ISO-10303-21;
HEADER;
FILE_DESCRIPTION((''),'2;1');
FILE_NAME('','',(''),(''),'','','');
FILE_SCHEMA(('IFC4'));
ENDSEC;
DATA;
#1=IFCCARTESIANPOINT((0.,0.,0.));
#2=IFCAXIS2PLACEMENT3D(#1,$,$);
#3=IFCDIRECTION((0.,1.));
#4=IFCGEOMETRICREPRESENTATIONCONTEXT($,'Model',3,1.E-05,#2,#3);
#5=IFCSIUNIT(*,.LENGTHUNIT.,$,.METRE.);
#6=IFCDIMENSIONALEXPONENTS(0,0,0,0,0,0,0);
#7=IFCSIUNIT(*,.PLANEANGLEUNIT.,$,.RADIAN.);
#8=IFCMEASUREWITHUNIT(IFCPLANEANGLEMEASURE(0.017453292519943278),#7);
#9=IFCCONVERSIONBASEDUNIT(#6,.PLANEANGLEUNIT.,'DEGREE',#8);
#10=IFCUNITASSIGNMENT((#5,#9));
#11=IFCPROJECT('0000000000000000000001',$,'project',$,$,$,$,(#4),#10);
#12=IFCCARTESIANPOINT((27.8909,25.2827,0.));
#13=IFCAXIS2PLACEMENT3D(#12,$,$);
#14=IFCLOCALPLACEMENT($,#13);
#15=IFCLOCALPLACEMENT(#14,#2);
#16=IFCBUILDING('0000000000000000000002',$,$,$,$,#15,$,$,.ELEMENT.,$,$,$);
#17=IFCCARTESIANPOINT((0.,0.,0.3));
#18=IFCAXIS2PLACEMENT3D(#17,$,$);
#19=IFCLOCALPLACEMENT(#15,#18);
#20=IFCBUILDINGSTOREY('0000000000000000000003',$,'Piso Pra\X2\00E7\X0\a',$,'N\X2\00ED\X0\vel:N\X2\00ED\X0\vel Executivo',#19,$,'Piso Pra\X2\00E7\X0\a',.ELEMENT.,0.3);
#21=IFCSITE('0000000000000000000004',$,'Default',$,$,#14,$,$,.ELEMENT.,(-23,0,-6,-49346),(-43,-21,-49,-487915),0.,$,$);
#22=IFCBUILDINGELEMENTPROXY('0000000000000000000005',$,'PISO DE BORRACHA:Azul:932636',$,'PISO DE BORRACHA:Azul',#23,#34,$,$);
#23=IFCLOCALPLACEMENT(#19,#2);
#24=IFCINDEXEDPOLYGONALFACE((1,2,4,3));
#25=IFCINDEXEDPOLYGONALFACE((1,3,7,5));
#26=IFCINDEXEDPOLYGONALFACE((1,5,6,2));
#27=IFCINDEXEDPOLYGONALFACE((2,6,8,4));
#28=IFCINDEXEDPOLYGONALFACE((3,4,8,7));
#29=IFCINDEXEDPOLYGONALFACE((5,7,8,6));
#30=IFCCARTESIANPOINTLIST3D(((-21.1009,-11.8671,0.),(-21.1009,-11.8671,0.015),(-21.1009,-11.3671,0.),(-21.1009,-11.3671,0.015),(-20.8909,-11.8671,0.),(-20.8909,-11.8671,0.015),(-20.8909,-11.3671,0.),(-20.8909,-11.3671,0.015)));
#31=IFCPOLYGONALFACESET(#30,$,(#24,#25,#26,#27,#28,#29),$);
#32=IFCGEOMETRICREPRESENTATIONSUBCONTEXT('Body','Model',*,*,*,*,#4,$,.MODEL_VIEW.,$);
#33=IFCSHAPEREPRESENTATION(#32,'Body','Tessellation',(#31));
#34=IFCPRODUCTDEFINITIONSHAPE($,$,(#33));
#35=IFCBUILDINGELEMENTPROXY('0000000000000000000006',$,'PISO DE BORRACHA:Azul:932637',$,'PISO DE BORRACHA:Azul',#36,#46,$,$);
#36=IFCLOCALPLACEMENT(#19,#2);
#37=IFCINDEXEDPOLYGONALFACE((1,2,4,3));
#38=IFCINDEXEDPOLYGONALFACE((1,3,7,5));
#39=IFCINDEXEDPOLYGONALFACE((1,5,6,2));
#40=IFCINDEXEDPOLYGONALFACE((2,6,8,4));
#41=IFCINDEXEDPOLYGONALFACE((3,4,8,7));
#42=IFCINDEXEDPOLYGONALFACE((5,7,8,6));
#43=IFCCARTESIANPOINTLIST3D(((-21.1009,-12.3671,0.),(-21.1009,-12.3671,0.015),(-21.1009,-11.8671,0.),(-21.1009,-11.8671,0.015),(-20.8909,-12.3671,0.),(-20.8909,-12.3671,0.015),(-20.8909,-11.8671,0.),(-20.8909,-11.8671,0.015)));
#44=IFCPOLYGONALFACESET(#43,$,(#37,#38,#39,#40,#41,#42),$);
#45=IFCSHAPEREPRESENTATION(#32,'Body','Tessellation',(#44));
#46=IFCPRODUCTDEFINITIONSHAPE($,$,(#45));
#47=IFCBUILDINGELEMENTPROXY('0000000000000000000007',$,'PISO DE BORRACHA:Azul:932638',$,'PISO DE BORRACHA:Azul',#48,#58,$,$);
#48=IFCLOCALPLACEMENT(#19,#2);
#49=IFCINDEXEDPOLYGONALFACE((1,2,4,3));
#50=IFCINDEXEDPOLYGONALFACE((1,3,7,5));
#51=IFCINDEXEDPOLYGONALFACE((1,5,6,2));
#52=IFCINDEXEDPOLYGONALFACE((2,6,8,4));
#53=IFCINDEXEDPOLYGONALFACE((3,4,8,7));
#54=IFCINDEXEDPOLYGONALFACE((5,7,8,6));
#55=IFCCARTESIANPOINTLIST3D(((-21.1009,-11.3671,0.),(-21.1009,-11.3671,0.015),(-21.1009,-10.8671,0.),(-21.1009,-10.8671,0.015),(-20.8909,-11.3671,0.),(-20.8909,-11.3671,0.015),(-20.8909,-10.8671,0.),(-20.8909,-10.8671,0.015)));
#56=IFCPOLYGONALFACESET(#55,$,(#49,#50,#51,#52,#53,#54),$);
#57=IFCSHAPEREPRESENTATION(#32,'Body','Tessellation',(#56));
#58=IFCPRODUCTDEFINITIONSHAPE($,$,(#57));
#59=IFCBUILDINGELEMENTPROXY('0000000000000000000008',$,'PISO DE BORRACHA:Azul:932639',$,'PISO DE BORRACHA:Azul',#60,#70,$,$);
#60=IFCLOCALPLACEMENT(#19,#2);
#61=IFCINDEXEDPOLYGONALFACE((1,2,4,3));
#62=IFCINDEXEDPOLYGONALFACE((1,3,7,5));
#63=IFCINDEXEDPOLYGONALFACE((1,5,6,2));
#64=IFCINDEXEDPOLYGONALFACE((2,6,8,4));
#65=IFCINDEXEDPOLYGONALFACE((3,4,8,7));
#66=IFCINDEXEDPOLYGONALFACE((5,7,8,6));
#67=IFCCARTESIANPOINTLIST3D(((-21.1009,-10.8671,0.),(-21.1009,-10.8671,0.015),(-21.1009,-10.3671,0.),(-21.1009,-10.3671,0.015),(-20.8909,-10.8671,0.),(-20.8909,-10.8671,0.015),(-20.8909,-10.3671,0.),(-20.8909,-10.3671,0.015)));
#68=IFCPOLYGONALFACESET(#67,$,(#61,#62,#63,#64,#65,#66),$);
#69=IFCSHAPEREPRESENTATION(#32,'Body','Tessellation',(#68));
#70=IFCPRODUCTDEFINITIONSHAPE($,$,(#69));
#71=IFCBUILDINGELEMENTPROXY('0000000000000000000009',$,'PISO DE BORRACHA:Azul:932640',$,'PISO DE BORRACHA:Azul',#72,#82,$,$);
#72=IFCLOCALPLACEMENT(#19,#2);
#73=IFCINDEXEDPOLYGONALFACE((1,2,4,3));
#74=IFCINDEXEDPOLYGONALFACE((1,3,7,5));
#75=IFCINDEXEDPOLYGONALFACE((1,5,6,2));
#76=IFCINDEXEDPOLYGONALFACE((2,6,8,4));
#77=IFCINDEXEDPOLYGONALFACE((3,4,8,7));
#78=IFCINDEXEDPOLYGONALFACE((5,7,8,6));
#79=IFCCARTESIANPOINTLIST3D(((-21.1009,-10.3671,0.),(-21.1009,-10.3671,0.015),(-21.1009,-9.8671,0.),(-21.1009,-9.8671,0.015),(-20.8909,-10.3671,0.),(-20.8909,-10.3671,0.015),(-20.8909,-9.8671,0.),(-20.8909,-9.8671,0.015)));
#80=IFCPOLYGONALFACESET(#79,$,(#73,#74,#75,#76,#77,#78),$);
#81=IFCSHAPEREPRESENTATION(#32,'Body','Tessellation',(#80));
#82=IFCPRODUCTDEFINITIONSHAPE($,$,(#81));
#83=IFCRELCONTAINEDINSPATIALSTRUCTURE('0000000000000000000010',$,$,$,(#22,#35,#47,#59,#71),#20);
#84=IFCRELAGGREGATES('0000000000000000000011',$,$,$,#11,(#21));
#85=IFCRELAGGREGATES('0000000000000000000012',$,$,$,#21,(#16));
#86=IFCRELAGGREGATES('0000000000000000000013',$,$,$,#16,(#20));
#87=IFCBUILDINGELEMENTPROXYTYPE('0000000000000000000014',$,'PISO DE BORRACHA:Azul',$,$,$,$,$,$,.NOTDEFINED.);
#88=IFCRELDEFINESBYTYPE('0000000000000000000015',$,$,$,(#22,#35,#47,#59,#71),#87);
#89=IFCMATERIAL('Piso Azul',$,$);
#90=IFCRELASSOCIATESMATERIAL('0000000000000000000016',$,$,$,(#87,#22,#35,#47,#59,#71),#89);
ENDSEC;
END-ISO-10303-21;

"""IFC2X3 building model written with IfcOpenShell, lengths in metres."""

from ifc_helpers import new_model, entity, si_unit, converted_unit, direction, frame, origin, origin_2d_with_axis, place, context, subcontext, project, spatial, rectangle, extrude, source, transform, mapped, material, type_object, type_shapes, element, save


model = new_model("IFC2X3")

# Units and contexts
model_context = context("Model", 3, precision=1e-05, world=origin(), true_north=direction((0.0, 1.0)))
body_context = subcontext(model_context, "Body", "Model", "MODEL_VIEW")
ifc_project = project(units=[si_unit("LENGTHUNIT", "METRE"), converted_unit("PLANEANGLEUNIT", "DEGREE", entity("IfcPlaneAngleMeasure", 0.017453292519943278), si_unit("PLANEANGLEUNIT", "RADIAN"), dimensions=[0, 0, 0, 0, 0, 0, 0])], contexts=[model_context])

# Site, building, storey
site_placement = place(None, frame((27.8909, 25.2827, 0.0)))
site = spatial("IfcSite", under=ifc_project, at=site_placement, Name="Default", CompositionType="ELEMENT", RefLatitude=(-23, 0, -6, -49346), RefLongitude=(-43, -21, -49, -487915), RefElevation=0.0)
building_placement = place(site_placement, origin())
building = spatial("IfcBuilding", under=site, at=building_placement, CompositionType="ELEMENT")
storey_placement = place(building_placement, frame((0.0, 0.0, 0.3)))
storey = spatial("IfcBuildingStorey", under=building, at=storey_placement, Name="Piso Praça", ObjectType="Nível:Nível Executivo", LongName="Piso Praça", CompositionType="ELEMENT", Elevation=0.3)

# Building element proxies
ifc_material_1 = material(Name="Piso Azul")
building_element_proxy_type_1 = type_object("IfcBuildingElementProxyType", Name="PISO DE BORRACHA:Azul", PredefinedType="NOTDEFINED", material=ifc_material_1)
shared_shape_1 = source(origin(), body_context, "Body", "SweptSolid", [
    extrude(rectangle(XDim=0.5, YDim=0.21, at=origin_2d_with_axis()), frame((0.25, 0.105, 0.0), z_axis=(0.0, 0.0, 1.0), x_axis=(-1.0, 0.0, 0.0)), (0.0, 0.0, 1.0), 0.015),
])
type_shapes(building_element_proxy_type_1, [shared_shape_1])
for number, where, z_axis, x_axis, name in (
    (1, (-21.1009, -11.3671, 0.0), (0.0, 0.0, 1.0), (0.0, -1.0, 0.0), "PISO DE BORRACHA:Azul:932636"),
    (2, (-21.1009, -11.8671, 0.0), (0.0, 0.0, 1.0), (0.0, -1.0, 0.0), "PISO DE BORRACHA:Azul:932637"),
    (3, (-21.1009, -10.8671, 0.0), (0.0, 0.0, 1.0), (0.0, -1.0, 0.0), "PISO DE BORRACHA:Azul:932638"),
    (4, (-21.1009, -10.3671, 0.0), (0.0, 0.0, 1.0), (0.0, -1.0, 0.0), "PISO DE BORRACHA:Azul:932639"),
    (5, (-21.1009, -9.8671, 0.0), (0.0, 0.0, 1.0), (0.0, -1.0, 0.0), "PISO DE BORRACHA:Azul:932640"),
):
    element("IfcBuildingElementProxy", number, at=place(storey_placement, frame(where, z_axis=z_axis, x_axis=x_axis)), inside=storey, type_object=building_element_proxy_type_1, material=ifc_material_1, Name=name, ObjectType="PISO DE BORRACHA:Azul", context=body_context, shape_type="MappedRepresentation", body=[
        mapped(shared_shape_1, transform((0.0, 0.0, 0.0), scale=1.0)),
    ])

save(model, "model.ifc")
